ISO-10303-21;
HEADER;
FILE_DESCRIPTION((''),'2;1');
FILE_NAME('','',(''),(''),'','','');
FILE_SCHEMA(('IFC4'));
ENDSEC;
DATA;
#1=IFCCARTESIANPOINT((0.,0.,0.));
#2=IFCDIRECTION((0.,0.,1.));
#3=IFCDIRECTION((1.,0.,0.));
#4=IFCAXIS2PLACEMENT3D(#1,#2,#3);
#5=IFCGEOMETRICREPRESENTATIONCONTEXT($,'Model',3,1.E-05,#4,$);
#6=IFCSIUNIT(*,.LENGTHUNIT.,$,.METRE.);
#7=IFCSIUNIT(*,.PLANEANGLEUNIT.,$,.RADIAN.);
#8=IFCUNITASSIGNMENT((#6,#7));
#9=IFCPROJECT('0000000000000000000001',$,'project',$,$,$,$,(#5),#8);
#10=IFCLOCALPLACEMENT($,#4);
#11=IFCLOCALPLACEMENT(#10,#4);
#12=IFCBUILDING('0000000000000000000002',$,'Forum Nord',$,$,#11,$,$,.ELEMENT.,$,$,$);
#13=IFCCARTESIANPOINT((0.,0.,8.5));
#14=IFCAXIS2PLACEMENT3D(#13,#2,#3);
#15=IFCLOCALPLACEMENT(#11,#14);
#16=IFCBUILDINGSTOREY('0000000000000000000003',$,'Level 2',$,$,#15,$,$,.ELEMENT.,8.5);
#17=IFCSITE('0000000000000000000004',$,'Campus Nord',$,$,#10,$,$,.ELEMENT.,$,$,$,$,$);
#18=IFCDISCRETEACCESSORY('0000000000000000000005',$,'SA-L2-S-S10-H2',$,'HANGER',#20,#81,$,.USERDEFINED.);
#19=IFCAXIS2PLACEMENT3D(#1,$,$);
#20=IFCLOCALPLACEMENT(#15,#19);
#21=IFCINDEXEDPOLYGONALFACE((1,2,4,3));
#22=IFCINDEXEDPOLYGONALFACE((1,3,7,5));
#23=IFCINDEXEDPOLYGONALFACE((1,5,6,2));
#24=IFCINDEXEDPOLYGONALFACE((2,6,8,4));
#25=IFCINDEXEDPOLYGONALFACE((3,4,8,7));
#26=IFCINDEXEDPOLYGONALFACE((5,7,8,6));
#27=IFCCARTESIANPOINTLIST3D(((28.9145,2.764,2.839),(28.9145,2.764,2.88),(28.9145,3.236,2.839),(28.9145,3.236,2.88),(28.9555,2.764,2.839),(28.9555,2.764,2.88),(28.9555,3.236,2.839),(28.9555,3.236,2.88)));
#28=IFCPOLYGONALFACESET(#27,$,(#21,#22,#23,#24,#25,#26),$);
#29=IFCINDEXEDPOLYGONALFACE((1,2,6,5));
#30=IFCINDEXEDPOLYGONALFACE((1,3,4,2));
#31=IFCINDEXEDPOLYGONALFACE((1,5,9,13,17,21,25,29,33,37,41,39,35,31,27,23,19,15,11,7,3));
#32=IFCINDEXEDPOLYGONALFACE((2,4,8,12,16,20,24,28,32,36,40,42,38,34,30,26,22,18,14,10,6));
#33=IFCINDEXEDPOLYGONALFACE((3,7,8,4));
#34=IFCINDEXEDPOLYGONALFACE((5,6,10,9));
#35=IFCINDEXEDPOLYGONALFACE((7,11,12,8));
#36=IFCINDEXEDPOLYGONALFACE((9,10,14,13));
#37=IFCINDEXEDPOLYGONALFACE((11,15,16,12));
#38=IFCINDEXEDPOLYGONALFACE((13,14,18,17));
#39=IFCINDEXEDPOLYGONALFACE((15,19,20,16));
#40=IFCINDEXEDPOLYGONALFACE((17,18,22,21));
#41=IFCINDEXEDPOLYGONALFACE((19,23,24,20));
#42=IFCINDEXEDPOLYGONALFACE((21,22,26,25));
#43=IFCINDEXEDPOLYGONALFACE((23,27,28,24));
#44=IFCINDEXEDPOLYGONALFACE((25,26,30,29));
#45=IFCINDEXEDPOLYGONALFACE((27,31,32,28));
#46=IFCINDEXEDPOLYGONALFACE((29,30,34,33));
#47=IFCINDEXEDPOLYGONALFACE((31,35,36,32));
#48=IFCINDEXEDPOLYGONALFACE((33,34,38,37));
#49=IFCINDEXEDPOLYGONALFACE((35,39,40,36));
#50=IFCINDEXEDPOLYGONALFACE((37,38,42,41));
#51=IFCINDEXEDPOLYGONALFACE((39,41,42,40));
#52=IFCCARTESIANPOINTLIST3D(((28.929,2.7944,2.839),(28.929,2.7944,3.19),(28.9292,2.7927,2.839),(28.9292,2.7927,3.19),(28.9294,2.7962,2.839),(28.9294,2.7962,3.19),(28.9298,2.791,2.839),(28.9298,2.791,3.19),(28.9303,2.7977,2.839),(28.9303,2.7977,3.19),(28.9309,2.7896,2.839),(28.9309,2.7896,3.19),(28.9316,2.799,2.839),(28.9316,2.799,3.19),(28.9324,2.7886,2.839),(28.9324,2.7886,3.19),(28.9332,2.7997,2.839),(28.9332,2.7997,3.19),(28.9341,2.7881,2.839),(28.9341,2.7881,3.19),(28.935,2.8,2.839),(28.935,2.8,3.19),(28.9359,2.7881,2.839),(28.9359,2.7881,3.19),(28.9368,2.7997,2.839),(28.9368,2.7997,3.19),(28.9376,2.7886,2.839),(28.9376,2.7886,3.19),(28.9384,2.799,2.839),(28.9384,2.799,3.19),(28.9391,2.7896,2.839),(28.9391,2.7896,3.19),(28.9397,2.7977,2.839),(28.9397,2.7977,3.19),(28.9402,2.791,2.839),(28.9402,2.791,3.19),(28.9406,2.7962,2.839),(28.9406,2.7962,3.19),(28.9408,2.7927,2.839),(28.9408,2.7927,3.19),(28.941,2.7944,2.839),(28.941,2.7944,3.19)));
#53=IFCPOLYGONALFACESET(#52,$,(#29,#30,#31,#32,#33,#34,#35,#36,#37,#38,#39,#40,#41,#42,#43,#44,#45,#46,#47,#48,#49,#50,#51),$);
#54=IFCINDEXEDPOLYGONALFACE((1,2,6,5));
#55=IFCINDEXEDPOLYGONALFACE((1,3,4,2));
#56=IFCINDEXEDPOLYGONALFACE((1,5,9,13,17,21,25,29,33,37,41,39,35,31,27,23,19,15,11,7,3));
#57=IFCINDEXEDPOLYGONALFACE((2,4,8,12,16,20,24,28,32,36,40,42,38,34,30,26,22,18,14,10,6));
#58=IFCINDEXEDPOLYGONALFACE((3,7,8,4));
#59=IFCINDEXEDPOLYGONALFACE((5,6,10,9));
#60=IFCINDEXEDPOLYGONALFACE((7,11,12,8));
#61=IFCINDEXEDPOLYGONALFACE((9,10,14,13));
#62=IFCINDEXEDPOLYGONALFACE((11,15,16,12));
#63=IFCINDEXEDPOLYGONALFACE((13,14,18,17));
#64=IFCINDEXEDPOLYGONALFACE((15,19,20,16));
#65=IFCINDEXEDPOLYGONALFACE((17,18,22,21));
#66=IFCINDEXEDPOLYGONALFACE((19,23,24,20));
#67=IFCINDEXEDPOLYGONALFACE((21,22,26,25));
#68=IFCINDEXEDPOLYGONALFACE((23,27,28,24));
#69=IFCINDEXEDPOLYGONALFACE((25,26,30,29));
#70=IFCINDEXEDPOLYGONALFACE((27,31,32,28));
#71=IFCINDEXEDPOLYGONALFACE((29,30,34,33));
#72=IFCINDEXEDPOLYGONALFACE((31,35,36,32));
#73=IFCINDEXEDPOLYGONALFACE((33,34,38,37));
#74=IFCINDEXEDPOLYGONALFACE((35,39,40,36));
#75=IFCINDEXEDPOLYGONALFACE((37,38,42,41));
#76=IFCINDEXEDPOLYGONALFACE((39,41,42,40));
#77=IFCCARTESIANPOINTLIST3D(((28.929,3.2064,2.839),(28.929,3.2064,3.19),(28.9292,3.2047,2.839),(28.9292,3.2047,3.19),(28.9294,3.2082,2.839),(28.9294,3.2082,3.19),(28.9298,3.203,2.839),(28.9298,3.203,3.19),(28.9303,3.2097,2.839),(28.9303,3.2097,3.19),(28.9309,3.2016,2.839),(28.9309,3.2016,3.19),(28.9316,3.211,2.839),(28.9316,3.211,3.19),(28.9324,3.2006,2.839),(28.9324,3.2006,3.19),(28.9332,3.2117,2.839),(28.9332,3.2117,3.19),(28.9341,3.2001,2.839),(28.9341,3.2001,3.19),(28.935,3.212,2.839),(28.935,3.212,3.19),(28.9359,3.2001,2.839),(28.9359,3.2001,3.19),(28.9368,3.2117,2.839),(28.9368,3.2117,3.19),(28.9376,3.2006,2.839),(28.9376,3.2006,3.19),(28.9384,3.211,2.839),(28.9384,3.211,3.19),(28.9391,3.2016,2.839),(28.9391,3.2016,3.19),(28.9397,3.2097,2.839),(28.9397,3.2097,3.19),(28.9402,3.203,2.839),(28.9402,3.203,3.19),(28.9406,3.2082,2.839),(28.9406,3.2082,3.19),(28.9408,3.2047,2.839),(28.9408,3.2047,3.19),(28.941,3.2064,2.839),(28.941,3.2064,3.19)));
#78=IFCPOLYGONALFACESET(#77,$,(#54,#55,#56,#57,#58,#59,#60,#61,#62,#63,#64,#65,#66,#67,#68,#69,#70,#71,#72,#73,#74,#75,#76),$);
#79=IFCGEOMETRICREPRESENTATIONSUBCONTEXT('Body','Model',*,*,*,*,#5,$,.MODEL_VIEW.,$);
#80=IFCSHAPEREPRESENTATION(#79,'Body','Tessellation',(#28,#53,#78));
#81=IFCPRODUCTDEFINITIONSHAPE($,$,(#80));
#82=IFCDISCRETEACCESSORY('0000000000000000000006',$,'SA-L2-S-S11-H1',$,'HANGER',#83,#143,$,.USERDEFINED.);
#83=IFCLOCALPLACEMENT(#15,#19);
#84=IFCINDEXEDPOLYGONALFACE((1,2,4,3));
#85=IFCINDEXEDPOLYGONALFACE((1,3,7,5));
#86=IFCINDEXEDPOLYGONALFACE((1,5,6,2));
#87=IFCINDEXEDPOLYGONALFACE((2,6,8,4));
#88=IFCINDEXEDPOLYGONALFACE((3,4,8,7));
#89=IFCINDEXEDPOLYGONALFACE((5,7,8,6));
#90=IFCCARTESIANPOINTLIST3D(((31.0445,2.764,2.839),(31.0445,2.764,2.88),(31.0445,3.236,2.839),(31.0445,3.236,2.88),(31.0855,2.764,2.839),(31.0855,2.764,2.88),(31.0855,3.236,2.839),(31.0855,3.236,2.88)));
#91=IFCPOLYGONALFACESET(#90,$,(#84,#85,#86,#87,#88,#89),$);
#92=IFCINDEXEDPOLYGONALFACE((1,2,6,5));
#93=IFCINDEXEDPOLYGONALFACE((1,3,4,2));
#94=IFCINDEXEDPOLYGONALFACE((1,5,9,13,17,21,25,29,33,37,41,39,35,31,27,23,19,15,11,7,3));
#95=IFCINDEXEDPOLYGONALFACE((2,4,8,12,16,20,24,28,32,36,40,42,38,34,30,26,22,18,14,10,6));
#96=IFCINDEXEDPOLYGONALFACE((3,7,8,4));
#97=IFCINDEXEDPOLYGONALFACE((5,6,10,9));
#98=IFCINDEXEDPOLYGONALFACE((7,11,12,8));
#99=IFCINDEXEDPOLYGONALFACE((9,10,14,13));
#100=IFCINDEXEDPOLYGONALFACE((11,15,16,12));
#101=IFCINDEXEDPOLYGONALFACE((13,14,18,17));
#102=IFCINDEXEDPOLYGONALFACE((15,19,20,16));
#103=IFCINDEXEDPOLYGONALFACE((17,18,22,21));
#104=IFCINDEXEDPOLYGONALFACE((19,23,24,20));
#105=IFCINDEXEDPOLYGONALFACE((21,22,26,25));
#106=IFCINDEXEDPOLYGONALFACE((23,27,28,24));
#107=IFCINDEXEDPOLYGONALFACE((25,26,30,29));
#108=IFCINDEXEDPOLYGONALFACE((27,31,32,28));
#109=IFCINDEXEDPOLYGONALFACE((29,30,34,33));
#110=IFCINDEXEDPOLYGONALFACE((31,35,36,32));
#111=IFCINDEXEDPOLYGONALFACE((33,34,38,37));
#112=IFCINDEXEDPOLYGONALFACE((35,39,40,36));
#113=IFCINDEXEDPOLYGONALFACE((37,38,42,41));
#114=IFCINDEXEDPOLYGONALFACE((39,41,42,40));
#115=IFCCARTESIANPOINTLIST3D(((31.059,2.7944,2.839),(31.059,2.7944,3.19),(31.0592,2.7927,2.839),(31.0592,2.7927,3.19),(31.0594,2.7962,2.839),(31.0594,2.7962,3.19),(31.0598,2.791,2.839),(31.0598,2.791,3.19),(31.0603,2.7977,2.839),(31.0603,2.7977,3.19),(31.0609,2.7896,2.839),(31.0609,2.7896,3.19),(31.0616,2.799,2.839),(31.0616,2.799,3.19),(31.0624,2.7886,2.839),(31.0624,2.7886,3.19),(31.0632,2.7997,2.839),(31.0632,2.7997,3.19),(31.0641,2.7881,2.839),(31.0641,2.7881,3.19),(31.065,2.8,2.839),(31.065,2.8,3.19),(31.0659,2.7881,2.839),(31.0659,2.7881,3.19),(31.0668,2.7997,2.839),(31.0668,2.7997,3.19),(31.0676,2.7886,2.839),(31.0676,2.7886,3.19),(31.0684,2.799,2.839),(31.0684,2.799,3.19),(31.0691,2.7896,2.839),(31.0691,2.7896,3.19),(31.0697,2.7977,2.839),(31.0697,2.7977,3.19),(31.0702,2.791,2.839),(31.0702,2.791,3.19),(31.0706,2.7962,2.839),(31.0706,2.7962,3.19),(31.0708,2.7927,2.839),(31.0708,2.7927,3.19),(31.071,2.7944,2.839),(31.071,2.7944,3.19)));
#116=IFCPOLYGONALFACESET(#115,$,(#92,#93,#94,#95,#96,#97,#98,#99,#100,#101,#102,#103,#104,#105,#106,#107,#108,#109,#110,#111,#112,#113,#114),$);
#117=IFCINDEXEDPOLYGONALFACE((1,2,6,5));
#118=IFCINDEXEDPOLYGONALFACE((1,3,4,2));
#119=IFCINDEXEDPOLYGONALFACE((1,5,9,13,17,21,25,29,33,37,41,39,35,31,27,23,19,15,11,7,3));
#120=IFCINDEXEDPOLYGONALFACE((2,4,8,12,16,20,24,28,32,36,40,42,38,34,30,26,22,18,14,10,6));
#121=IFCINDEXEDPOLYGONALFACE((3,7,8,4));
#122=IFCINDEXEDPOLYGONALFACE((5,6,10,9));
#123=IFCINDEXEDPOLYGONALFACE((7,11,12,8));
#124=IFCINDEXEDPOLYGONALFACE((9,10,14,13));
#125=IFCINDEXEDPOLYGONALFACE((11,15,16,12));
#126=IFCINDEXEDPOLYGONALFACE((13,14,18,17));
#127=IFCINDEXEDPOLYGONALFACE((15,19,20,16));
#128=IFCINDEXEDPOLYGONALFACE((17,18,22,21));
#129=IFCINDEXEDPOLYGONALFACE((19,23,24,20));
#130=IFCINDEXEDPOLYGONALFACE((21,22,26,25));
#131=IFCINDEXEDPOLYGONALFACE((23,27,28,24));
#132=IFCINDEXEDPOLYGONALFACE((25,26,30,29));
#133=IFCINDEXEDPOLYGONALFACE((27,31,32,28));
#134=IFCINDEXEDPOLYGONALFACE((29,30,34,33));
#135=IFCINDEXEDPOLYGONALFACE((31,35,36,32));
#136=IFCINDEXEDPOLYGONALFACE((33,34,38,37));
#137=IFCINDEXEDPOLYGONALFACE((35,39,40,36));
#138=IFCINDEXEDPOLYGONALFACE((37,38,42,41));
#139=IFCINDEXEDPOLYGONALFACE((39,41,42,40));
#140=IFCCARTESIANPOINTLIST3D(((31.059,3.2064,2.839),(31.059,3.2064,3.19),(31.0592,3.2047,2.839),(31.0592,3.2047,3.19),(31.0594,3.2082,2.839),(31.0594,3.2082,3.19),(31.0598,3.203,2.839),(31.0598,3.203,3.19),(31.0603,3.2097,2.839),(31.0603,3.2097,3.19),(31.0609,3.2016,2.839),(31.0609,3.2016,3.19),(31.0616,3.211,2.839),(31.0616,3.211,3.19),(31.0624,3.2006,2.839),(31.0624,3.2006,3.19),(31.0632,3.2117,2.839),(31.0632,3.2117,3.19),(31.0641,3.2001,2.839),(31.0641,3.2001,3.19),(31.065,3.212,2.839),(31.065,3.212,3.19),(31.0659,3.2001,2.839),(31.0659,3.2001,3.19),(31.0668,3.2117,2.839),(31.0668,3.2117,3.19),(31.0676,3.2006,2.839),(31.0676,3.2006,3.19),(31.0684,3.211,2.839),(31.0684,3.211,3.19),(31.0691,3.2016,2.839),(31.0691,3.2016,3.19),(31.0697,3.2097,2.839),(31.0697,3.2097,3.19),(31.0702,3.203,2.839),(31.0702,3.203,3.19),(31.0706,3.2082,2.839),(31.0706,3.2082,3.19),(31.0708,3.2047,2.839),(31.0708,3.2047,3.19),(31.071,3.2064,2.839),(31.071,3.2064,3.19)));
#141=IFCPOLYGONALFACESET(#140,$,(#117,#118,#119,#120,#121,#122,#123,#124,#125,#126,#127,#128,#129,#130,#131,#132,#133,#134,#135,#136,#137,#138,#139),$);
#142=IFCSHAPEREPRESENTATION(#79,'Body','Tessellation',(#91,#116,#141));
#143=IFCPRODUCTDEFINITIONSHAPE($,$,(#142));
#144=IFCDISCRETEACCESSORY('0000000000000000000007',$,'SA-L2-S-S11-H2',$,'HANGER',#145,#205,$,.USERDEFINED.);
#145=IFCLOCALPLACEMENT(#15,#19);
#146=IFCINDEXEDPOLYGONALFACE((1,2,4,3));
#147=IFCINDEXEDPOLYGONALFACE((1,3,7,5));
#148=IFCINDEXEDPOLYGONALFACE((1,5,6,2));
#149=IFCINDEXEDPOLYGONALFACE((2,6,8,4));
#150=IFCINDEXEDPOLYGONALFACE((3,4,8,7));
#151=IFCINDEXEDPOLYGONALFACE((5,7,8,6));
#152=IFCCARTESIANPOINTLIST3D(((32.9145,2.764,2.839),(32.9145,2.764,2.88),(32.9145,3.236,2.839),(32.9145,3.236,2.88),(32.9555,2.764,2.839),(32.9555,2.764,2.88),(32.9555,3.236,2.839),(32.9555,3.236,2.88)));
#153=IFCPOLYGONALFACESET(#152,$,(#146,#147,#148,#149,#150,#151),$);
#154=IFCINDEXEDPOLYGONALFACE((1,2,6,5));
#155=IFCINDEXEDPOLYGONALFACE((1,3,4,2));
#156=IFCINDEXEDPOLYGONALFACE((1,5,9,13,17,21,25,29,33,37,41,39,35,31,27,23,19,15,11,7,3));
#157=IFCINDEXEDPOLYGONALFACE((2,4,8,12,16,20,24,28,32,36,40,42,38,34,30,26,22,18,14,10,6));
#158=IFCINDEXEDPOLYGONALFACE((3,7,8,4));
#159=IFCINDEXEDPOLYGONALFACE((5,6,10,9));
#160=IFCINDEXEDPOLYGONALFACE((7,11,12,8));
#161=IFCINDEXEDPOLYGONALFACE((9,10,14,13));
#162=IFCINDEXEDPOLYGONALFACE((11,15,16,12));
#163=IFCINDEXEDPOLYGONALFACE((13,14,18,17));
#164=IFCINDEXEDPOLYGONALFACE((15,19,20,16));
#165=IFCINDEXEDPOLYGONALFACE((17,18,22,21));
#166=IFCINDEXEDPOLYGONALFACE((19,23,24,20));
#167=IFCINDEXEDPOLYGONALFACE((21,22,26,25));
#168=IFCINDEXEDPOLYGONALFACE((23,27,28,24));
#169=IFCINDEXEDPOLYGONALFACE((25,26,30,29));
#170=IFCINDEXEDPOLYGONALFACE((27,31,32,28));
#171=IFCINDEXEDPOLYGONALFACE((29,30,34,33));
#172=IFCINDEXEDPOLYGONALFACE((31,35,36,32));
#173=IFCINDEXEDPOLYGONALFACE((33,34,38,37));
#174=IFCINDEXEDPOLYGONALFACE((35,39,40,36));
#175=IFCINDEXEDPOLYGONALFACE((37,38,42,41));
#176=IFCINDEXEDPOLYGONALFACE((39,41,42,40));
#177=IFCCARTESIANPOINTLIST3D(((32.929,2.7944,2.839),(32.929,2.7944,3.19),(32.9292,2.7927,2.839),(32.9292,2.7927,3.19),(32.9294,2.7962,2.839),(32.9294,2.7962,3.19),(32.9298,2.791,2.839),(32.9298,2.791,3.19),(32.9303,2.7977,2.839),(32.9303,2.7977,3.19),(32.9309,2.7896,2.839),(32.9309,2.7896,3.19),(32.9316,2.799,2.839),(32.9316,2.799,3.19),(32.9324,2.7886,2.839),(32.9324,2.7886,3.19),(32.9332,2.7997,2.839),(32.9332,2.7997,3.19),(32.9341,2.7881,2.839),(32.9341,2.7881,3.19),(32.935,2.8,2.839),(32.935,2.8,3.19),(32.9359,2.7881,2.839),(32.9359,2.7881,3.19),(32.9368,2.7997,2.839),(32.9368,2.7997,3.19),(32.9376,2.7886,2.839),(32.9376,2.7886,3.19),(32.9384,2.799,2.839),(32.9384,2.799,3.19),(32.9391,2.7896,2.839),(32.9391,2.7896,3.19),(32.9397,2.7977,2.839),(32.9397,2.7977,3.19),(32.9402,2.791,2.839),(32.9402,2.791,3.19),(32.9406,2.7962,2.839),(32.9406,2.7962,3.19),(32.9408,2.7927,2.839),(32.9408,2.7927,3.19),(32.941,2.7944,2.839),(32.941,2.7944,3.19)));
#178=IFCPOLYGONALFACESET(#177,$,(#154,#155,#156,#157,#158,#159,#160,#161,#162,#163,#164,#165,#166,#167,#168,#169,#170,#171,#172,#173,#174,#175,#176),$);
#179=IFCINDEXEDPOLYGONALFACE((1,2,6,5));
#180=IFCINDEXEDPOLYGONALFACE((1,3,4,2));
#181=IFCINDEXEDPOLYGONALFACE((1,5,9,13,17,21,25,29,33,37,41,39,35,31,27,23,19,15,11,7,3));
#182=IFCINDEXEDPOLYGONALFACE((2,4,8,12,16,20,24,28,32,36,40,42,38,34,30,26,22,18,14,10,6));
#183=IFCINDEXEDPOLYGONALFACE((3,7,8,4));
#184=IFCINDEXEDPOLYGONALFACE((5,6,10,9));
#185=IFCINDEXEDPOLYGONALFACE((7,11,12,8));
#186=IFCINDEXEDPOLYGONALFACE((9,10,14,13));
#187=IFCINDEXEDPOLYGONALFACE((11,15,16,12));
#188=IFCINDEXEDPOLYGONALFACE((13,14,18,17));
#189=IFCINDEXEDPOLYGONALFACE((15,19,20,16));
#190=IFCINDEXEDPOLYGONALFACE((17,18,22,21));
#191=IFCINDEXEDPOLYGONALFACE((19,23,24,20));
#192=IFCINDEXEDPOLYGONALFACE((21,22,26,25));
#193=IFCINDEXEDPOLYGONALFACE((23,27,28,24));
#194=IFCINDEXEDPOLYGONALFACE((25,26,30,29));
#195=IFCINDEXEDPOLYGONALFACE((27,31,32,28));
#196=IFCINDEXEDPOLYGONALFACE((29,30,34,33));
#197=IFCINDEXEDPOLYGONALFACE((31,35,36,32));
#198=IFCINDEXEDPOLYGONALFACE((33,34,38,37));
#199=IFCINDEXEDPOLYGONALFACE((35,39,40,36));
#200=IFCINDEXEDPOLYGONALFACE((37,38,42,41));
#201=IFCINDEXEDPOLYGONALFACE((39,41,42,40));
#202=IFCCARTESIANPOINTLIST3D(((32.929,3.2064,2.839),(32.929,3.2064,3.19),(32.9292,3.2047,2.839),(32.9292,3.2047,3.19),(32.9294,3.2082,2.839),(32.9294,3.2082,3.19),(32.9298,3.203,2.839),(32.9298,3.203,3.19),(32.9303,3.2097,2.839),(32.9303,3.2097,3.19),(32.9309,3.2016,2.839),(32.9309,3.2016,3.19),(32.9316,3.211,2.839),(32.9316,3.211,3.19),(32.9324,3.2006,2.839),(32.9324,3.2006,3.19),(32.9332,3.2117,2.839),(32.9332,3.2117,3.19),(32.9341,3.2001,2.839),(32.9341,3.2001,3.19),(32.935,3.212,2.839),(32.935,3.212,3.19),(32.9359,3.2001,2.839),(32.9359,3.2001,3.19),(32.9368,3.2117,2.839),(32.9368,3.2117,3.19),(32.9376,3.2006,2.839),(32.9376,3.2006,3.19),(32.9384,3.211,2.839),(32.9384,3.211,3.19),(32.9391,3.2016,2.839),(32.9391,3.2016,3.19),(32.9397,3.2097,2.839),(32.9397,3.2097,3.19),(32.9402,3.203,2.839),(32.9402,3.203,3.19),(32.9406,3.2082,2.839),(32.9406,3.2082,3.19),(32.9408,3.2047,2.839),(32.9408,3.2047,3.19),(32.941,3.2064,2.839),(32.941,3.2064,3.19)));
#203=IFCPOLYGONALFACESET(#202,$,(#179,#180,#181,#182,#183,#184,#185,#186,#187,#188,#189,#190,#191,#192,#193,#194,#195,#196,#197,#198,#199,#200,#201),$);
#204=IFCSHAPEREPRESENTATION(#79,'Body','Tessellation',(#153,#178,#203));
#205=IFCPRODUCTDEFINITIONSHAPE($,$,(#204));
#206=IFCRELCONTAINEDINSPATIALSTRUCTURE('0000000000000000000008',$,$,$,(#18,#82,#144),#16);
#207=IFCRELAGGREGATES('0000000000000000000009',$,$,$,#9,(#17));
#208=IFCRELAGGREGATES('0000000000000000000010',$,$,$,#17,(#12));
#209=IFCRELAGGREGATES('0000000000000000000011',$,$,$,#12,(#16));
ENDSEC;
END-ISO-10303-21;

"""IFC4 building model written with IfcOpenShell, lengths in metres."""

from ifc_helpers import new_model, si_unit, frame, frame_2d, origin_with_axes, origin_2d_with_axis, place, context, subcontext, project, spatial, rectangle, circle, extrude, element, save


model = new_model("IFC4")

# Units and contexts
model_context = context("Model", 3, precision=1e-05, world=origin_with_axes())
body_context = subcontext(model_context, "Body", "Model", "MODEL_VIEW")
ifc_project = project(units=[si_unit("LENGTHUNIT", "METRE"), si_unit("PLANEANGLEUNIT", "RADIAN")], contexts=[model_context])

# Site, building, storey
site_placement = place(None, origin_with_axes())
site = spatial("IfcSite", under=ifc_project, at=site_placement, Name="Campus Nord", CompositionType="ELEMENT")
building_placement = place(site_placement, origin_with_axes())
building = spatial("IfcBuilding", under=site, at=building_placement, Name="Forum Nord", CompositionType="ELEMENT")
storey_placement = place(building_placement, frame((0.0, 0.0, 8.5), z_axis=(0.0, 0.0, 1.0), x_axis=(1.0, 0.0, 0.0)))
storey = spatial("IfcBuildingStorey", under=building, at=storey_placement, Name="Level 2", CompositionType="ELEMENT", Elevation=8.5)

# Discrete accessories
for number, where, z_axis, x_axis, name in (
    (1, (28.935, 3.0, 2.88), (0.0, 0.0, 1.0), (0.0, 1.0, 0.0), "SA-L2-S-S10-H2"),
    (2, (31.065, 3.0, 2.88), (0.0, 0.0, 1.0), (0.0, 1.0, 0.0), "SA-L2-S-S11-H1"),
    (3, (32.935, 3.0, 2.88), (0.0, 0.0, 1.0), (0.0, 1.0, 0.0), "SA-L2-S-S11-H2"),
):
    element("IfcDiscreteAccessory", number, at=place(storey_placement, frame(where, z_axis=z_axis, x_axis=x_axis)), inside=storey, Name=name, ObjectType="HANGER", PredefinedType="USERDEFINED", context=body_context, shape_type="SweptSolid", body=[
        extrude(rectangle(XDim=0.472, YDim=0.041, at=origin_2d_with_axis()), frame((0.0, 0.0, -0.041), z_axis=(0.0, 0.0, 1.0), x_axis=(1.0, 0.0, 0.0)), (0.0, 0.0, 1.0), 0.041),
        extrude(circle(Radius=0.006, at=frame_2d((-0.206, 0.0), x_axis=(1.0, 0.0))), frame((0.0, 0.0, -0.041), z_axis=(0.0, 0.0, 1.0), x_axis=(1.0, 0.0, 0.0)), (0.0, 0.0, 1.0), 0.351),
        extrude(circle(Radius=0.006, at=frame_2d((0.206, 0.0), x_axis=(1.0, 0.0))), frame((0.0, 0.0, -0.041), z_axis=(0.0, 0.0, 1.0), x_axis=(1.0, 0.0, 0.0)), (0.0, 0.0, 1.0), 0.351),
    ])

save(model, "model.ifc")
